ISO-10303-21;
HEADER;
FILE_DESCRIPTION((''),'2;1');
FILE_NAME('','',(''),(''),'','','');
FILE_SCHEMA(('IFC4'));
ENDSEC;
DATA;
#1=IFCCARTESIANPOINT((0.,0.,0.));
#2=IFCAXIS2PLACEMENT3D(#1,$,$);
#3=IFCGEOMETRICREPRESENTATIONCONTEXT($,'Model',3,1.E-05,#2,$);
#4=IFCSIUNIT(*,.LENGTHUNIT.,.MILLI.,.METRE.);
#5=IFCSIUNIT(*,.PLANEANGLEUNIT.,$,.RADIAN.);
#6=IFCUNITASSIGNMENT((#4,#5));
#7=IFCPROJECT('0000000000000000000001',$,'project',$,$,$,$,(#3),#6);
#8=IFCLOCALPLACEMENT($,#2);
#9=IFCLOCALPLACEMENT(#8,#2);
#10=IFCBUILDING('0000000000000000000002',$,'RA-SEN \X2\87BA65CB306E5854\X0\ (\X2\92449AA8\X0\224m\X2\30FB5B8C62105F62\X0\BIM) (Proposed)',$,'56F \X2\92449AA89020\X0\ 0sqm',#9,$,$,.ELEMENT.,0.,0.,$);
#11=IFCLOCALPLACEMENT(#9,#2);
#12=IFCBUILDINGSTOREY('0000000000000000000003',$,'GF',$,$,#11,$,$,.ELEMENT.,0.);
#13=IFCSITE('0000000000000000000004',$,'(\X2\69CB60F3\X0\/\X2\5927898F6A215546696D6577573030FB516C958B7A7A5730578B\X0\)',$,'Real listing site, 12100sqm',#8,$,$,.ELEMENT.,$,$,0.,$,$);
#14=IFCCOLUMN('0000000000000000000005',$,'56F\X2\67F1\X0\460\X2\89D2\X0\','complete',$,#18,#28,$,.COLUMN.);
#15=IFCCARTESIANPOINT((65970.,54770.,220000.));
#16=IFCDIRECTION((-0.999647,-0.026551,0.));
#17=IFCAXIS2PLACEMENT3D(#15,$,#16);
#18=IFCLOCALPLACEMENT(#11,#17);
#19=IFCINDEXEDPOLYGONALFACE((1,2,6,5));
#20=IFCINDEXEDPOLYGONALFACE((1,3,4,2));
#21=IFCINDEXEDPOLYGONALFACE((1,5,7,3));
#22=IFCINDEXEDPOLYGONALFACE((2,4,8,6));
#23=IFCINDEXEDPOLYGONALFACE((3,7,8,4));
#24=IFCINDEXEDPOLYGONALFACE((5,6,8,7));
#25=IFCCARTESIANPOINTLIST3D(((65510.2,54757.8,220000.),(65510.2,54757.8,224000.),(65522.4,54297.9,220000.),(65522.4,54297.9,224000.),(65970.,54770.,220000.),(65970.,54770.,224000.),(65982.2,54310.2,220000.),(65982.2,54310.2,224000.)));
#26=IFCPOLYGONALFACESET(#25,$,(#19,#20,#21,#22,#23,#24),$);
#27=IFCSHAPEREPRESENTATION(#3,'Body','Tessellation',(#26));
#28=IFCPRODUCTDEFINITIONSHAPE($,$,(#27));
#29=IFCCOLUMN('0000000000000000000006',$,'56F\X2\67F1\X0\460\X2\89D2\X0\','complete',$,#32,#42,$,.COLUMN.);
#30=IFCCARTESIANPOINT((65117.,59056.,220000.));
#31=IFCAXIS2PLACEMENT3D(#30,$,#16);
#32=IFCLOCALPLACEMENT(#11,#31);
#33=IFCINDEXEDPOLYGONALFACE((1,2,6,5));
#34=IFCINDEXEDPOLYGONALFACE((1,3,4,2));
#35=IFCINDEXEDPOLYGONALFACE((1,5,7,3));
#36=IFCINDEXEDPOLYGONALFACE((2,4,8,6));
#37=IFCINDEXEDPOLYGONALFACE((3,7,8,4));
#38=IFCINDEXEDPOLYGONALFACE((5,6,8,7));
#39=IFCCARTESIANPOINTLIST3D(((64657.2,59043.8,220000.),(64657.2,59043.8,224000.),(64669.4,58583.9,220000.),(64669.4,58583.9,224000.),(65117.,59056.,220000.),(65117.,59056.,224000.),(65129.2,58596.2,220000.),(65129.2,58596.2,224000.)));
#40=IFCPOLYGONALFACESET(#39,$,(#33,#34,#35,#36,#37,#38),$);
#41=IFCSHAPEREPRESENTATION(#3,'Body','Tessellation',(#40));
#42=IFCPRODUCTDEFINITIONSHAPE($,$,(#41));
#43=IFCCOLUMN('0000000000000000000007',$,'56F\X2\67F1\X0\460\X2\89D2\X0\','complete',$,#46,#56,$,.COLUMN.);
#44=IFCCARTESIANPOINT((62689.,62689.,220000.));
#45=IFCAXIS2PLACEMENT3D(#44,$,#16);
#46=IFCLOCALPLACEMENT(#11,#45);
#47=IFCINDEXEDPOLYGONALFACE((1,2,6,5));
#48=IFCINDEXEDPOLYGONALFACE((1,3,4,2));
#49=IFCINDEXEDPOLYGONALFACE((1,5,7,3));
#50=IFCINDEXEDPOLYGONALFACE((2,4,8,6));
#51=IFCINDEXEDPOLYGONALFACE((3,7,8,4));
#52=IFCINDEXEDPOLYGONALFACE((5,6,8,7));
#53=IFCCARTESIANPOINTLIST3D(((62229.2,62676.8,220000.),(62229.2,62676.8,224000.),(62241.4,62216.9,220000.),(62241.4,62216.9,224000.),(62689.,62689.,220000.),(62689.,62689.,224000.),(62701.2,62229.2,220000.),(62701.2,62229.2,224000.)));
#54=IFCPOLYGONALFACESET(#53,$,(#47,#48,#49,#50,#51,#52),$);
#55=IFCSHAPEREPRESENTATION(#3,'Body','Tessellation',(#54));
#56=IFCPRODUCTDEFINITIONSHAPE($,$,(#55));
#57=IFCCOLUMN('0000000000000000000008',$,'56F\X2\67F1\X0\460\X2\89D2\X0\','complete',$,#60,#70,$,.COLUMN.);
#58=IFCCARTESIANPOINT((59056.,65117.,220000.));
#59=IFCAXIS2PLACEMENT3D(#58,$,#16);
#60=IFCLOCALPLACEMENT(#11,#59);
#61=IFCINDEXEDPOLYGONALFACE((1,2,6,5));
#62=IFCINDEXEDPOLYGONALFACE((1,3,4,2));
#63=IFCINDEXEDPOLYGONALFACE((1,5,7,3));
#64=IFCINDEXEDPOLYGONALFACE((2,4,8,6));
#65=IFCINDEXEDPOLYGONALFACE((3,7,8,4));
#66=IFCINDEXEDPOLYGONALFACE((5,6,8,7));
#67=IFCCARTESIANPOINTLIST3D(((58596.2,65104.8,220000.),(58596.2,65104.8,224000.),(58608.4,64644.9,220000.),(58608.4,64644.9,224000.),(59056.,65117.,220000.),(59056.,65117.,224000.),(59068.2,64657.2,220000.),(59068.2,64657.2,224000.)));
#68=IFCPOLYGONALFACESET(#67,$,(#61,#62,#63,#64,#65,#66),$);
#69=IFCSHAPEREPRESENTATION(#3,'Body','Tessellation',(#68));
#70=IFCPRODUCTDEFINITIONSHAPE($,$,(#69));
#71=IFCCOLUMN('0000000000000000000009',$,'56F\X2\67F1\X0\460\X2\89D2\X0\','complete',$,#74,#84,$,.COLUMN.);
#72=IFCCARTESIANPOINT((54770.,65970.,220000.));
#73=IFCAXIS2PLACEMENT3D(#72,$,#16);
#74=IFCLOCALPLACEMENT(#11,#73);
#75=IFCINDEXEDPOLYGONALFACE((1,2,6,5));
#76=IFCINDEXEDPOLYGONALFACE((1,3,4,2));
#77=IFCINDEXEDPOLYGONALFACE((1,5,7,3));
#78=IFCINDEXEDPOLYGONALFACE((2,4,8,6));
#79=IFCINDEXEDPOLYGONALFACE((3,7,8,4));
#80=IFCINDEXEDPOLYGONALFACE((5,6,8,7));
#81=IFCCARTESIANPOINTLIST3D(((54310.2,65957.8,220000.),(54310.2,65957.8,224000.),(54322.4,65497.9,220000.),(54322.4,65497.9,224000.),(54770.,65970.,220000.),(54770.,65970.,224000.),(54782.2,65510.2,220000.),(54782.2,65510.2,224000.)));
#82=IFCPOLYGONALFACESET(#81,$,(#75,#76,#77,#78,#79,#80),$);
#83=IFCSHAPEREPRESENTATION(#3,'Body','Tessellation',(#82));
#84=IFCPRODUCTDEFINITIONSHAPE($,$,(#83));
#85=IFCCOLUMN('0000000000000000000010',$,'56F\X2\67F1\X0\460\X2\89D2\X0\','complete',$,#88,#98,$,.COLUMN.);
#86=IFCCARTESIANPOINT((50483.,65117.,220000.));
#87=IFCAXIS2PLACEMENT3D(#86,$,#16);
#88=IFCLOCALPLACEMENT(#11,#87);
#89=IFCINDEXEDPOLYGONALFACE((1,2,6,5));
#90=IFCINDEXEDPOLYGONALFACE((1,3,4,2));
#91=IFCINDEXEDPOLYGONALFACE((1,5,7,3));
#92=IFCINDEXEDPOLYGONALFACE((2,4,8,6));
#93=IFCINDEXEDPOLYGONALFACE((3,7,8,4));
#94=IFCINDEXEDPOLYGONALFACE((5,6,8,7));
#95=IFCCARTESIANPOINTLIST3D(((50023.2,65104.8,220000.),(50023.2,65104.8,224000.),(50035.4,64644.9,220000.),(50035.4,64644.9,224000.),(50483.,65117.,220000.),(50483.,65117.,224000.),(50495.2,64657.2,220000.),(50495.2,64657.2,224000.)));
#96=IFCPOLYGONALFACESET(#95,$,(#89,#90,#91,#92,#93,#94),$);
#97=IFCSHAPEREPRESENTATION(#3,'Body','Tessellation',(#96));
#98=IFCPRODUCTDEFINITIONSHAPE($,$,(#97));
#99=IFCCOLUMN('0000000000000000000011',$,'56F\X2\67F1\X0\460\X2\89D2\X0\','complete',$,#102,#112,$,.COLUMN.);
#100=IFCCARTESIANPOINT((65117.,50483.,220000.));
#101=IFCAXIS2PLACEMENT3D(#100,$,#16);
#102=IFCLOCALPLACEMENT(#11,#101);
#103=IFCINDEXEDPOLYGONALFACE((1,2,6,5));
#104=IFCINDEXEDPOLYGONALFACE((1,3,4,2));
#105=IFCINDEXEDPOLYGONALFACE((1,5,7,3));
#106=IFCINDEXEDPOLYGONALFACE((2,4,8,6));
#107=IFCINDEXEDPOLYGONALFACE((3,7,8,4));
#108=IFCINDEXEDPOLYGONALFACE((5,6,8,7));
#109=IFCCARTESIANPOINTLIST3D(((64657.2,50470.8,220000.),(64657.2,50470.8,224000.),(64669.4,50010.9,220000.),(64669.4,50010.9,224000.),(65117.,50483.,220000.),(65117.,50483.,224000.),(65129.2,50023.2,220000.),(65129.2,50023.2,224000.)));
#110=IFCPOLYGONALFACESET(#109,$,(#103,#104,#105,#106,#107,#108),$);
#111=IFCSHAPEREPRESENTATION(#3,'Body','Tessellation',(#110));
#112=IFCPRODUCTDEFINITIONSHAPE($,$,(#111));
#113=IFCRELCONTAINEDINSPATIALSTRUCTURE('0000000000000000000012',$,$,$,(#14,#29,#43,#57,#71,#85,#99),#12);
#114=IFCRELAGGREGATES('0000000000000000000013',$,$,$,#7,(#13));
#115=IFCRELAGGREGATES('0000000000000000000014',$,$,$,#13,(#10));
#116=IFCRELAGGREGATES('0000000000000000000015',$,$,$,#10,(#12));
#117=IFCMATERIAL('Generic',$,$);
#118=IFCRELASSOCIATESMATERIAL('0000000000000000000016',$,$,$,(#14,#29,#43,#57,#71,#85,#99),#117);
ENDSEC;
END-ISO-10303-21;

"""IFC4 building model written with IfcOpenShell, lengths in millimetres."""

from ifc_helpers import new_model, si_unit, frame, frame_2d, origin, place, context, project, spatial, rectangle, extrude, material, element, save


model = new_model("IFC4")

# Units and contexts
model_context = context("Model", 3, precision=1e-05, world=origin())
ifc_project = project(units=[si_unit("LENGTHUNIT", "METRE", prefix="MILLI"), si_unit("PLANEANGLEUNIT", "RADIAN")], contexts=[model_context])

# Site, building, storey
site_placement = place(None, origin())
site = spatial("IfcSite", under=ifc_project, at=site_placement, Name="(構想/大規模商業敷地・公開空地型)", ObjectType="Real listing site, 12100sqm", CompositionType="ELEMENT", RefElevation=0.0)
building_placement = place(site_placement, origin())
building = spatial("IfcBuilding", under=site, at=building_placement, Name="RA-SEN 螺旋の塔 (鉄骨224m・完成形BIM) (Proposed)", ObjectType="56F 鉄骨造 0sqm", CompositionType="ELEMENT", ElevationOfRefHeight=0.0, ElevationOfTerrain=0.0)
storey_placement = place(building_placement, origin())
storey = spatial("IfcBuildingStorey", under=building, at=storey_placement, Name="GF", CompositionType="ELEMENT", Elevation=0.0)

# Columns
ifc_material = material(Name="Generic")
column_1_placement = place(storey_placement, frame((65970.0, 54770.0, 220000.0), x_axis=(-0.999647, -0.026551, 0.0)))
element("IfcColumn", 1, at=column_1_placement, inside=storey, material=ifc_material, Name="56F柱460角", Description="complete", PredefinedType="COLUMN", context=model_context, shape_type="SweptSolid", body=[
    extrude(rectangle(XDim=460.0, YDim=460.0, at=frame_2d((230.0, 230.0))), frame((65970.0, 54770.0, 220000.0), x_axis=(-0.999647, -0.026551, 0.0)), (0.0, 0.0, 1.0), 4000.0),
])
column_2_placement = place(storey_placement, frame((65117.0, 59056.0, 220000.0), x_axis=(-0.999647, -0.026551, 0.0)))
element("IfcColumn", 2, at=column_2_placement, inside=storey, material=ifc_material, Name="56F柱460角", Description="complete", PredefinedType="COLUMN", context=model_context, shape_type="SweptSolid", body=[
    extrude(rectangle(XDim=460.0, YDim=460.0, at=frame_2d((230.0, 230.0))), frame((65117.0, 59056.0, 220000.0), x_axis=(-0.999647, -0.026551, 0.0)), (0.0, 0.0, 1.0), 4000.0),
])
column_3_placement = place(storey_placement, frame((62689.0, 62689.0, 220000.0), x_axis=(-0.999647, -0.026551, 0.0)))
element("IfcColumn", 3, at=column_3_placement, inside=storey, material=ifc_material, Name="56F柱460角", Description="complete", PredefinedType="COLUMN", context=model_context, shape_type="SweptSolid", body=[
    extrude(rectangle(XDim=460.0, YDim=460.0, at=frame_2d((230.0, 230.0))), frame((62689.0, 62689.0, 220000.0), x_axis=(-0.999647, -0.026551, 0.0)), (0.0, 0.0, 1.0), 4000.0),
])
column_4_placement = place(storey_placement, frame((59056.0, 65117.0, 220000.0), x_axis=(-0.999647, -0.026551, 0.0)))
element("IfcColumn", 4, at=column_4_placement, inside=storey, material=ifc_material, Name="56F柱460角", Description="complete", PredefinedType="COLUMN", context=model_context, shape_type="SweptSolid", body=[
    extrude(rectangle(XDim=460.0, YDim=460.0, at=frame_2d((230.0, 230.0))), frame((59056.0, 65117.0, 220000.0), x_axis=(-0.999647, -0.026551, 0.0)), (0.0, 0.0, 1.0), 4000.0),
])
column_5_placement = place(storey_placement, frame((54770.0, 65970.0, 220000.0), x_axis=(-0.999647, -0.026551, 0.0)))
element("IfcColumn", 5, at=column_5_placement, inside=storey, material=ifc_material, Name="56F柱460角", Description="complete", PredefinedType="COLUMN", context=model_context, shape_type="SweptSolid", body=[
    extrude(rectangle(XDim=460.0, YDim=460.0, at=frame_2d((230.0, 230.0))), frame((54770.0, 65970.0, 220000.0), x_axis=(-0.999647, -0.026551, 0.0)), (0.0, 0.0, 1.0), 4000.0),
])
column_6_placement = place(storey_placement, frame((50483.0, 65117.0, 220000.0), x_axis=(-0.999647, -0.026551, 0.0)))
element("IfcColumn", 6, at=column_6_placement, inside=storey, material=ifc_material, Name="56F柱460角", Description="complete", PredefinedType="COLUMN", context=model_context, shape_type="SweptSolid", body=[
    extrude(rectangle(XDim=460.0, YDim=460.0, at=frame_2d((230.0, 230.0))), frame((50483.0, 65117.0, 220000.0), x_axis=(-0.999647, -0.026551, 0.0)), (0.0, 0.0, 1.0), 4000.0),
])
column_7_placement = place(storey_placement, frame((65117.0, 50483.0, 220000.0), x_axis=(-0.999647, -0.026551, 0.0)))
element("IfcColumn", 7, at=column_7_placement, inside=storey, material=ifc_material, Name="56F柱460角", Description="complete", PredefinedType="COLUMN", context=model_context, shape_type="SweptSolid", body=[
    extrude(rectangle(XDim=460.0, YDim=460.0, at=frame_2d((230.0, 230.0))), frame((65117.0, 50483.0, 220000.0), x_axis=(-0.999647, -0.026551, 0.0)), (0.0, 0.0, 1.0), 4000.0),
])

save(model, "model.ifc")
